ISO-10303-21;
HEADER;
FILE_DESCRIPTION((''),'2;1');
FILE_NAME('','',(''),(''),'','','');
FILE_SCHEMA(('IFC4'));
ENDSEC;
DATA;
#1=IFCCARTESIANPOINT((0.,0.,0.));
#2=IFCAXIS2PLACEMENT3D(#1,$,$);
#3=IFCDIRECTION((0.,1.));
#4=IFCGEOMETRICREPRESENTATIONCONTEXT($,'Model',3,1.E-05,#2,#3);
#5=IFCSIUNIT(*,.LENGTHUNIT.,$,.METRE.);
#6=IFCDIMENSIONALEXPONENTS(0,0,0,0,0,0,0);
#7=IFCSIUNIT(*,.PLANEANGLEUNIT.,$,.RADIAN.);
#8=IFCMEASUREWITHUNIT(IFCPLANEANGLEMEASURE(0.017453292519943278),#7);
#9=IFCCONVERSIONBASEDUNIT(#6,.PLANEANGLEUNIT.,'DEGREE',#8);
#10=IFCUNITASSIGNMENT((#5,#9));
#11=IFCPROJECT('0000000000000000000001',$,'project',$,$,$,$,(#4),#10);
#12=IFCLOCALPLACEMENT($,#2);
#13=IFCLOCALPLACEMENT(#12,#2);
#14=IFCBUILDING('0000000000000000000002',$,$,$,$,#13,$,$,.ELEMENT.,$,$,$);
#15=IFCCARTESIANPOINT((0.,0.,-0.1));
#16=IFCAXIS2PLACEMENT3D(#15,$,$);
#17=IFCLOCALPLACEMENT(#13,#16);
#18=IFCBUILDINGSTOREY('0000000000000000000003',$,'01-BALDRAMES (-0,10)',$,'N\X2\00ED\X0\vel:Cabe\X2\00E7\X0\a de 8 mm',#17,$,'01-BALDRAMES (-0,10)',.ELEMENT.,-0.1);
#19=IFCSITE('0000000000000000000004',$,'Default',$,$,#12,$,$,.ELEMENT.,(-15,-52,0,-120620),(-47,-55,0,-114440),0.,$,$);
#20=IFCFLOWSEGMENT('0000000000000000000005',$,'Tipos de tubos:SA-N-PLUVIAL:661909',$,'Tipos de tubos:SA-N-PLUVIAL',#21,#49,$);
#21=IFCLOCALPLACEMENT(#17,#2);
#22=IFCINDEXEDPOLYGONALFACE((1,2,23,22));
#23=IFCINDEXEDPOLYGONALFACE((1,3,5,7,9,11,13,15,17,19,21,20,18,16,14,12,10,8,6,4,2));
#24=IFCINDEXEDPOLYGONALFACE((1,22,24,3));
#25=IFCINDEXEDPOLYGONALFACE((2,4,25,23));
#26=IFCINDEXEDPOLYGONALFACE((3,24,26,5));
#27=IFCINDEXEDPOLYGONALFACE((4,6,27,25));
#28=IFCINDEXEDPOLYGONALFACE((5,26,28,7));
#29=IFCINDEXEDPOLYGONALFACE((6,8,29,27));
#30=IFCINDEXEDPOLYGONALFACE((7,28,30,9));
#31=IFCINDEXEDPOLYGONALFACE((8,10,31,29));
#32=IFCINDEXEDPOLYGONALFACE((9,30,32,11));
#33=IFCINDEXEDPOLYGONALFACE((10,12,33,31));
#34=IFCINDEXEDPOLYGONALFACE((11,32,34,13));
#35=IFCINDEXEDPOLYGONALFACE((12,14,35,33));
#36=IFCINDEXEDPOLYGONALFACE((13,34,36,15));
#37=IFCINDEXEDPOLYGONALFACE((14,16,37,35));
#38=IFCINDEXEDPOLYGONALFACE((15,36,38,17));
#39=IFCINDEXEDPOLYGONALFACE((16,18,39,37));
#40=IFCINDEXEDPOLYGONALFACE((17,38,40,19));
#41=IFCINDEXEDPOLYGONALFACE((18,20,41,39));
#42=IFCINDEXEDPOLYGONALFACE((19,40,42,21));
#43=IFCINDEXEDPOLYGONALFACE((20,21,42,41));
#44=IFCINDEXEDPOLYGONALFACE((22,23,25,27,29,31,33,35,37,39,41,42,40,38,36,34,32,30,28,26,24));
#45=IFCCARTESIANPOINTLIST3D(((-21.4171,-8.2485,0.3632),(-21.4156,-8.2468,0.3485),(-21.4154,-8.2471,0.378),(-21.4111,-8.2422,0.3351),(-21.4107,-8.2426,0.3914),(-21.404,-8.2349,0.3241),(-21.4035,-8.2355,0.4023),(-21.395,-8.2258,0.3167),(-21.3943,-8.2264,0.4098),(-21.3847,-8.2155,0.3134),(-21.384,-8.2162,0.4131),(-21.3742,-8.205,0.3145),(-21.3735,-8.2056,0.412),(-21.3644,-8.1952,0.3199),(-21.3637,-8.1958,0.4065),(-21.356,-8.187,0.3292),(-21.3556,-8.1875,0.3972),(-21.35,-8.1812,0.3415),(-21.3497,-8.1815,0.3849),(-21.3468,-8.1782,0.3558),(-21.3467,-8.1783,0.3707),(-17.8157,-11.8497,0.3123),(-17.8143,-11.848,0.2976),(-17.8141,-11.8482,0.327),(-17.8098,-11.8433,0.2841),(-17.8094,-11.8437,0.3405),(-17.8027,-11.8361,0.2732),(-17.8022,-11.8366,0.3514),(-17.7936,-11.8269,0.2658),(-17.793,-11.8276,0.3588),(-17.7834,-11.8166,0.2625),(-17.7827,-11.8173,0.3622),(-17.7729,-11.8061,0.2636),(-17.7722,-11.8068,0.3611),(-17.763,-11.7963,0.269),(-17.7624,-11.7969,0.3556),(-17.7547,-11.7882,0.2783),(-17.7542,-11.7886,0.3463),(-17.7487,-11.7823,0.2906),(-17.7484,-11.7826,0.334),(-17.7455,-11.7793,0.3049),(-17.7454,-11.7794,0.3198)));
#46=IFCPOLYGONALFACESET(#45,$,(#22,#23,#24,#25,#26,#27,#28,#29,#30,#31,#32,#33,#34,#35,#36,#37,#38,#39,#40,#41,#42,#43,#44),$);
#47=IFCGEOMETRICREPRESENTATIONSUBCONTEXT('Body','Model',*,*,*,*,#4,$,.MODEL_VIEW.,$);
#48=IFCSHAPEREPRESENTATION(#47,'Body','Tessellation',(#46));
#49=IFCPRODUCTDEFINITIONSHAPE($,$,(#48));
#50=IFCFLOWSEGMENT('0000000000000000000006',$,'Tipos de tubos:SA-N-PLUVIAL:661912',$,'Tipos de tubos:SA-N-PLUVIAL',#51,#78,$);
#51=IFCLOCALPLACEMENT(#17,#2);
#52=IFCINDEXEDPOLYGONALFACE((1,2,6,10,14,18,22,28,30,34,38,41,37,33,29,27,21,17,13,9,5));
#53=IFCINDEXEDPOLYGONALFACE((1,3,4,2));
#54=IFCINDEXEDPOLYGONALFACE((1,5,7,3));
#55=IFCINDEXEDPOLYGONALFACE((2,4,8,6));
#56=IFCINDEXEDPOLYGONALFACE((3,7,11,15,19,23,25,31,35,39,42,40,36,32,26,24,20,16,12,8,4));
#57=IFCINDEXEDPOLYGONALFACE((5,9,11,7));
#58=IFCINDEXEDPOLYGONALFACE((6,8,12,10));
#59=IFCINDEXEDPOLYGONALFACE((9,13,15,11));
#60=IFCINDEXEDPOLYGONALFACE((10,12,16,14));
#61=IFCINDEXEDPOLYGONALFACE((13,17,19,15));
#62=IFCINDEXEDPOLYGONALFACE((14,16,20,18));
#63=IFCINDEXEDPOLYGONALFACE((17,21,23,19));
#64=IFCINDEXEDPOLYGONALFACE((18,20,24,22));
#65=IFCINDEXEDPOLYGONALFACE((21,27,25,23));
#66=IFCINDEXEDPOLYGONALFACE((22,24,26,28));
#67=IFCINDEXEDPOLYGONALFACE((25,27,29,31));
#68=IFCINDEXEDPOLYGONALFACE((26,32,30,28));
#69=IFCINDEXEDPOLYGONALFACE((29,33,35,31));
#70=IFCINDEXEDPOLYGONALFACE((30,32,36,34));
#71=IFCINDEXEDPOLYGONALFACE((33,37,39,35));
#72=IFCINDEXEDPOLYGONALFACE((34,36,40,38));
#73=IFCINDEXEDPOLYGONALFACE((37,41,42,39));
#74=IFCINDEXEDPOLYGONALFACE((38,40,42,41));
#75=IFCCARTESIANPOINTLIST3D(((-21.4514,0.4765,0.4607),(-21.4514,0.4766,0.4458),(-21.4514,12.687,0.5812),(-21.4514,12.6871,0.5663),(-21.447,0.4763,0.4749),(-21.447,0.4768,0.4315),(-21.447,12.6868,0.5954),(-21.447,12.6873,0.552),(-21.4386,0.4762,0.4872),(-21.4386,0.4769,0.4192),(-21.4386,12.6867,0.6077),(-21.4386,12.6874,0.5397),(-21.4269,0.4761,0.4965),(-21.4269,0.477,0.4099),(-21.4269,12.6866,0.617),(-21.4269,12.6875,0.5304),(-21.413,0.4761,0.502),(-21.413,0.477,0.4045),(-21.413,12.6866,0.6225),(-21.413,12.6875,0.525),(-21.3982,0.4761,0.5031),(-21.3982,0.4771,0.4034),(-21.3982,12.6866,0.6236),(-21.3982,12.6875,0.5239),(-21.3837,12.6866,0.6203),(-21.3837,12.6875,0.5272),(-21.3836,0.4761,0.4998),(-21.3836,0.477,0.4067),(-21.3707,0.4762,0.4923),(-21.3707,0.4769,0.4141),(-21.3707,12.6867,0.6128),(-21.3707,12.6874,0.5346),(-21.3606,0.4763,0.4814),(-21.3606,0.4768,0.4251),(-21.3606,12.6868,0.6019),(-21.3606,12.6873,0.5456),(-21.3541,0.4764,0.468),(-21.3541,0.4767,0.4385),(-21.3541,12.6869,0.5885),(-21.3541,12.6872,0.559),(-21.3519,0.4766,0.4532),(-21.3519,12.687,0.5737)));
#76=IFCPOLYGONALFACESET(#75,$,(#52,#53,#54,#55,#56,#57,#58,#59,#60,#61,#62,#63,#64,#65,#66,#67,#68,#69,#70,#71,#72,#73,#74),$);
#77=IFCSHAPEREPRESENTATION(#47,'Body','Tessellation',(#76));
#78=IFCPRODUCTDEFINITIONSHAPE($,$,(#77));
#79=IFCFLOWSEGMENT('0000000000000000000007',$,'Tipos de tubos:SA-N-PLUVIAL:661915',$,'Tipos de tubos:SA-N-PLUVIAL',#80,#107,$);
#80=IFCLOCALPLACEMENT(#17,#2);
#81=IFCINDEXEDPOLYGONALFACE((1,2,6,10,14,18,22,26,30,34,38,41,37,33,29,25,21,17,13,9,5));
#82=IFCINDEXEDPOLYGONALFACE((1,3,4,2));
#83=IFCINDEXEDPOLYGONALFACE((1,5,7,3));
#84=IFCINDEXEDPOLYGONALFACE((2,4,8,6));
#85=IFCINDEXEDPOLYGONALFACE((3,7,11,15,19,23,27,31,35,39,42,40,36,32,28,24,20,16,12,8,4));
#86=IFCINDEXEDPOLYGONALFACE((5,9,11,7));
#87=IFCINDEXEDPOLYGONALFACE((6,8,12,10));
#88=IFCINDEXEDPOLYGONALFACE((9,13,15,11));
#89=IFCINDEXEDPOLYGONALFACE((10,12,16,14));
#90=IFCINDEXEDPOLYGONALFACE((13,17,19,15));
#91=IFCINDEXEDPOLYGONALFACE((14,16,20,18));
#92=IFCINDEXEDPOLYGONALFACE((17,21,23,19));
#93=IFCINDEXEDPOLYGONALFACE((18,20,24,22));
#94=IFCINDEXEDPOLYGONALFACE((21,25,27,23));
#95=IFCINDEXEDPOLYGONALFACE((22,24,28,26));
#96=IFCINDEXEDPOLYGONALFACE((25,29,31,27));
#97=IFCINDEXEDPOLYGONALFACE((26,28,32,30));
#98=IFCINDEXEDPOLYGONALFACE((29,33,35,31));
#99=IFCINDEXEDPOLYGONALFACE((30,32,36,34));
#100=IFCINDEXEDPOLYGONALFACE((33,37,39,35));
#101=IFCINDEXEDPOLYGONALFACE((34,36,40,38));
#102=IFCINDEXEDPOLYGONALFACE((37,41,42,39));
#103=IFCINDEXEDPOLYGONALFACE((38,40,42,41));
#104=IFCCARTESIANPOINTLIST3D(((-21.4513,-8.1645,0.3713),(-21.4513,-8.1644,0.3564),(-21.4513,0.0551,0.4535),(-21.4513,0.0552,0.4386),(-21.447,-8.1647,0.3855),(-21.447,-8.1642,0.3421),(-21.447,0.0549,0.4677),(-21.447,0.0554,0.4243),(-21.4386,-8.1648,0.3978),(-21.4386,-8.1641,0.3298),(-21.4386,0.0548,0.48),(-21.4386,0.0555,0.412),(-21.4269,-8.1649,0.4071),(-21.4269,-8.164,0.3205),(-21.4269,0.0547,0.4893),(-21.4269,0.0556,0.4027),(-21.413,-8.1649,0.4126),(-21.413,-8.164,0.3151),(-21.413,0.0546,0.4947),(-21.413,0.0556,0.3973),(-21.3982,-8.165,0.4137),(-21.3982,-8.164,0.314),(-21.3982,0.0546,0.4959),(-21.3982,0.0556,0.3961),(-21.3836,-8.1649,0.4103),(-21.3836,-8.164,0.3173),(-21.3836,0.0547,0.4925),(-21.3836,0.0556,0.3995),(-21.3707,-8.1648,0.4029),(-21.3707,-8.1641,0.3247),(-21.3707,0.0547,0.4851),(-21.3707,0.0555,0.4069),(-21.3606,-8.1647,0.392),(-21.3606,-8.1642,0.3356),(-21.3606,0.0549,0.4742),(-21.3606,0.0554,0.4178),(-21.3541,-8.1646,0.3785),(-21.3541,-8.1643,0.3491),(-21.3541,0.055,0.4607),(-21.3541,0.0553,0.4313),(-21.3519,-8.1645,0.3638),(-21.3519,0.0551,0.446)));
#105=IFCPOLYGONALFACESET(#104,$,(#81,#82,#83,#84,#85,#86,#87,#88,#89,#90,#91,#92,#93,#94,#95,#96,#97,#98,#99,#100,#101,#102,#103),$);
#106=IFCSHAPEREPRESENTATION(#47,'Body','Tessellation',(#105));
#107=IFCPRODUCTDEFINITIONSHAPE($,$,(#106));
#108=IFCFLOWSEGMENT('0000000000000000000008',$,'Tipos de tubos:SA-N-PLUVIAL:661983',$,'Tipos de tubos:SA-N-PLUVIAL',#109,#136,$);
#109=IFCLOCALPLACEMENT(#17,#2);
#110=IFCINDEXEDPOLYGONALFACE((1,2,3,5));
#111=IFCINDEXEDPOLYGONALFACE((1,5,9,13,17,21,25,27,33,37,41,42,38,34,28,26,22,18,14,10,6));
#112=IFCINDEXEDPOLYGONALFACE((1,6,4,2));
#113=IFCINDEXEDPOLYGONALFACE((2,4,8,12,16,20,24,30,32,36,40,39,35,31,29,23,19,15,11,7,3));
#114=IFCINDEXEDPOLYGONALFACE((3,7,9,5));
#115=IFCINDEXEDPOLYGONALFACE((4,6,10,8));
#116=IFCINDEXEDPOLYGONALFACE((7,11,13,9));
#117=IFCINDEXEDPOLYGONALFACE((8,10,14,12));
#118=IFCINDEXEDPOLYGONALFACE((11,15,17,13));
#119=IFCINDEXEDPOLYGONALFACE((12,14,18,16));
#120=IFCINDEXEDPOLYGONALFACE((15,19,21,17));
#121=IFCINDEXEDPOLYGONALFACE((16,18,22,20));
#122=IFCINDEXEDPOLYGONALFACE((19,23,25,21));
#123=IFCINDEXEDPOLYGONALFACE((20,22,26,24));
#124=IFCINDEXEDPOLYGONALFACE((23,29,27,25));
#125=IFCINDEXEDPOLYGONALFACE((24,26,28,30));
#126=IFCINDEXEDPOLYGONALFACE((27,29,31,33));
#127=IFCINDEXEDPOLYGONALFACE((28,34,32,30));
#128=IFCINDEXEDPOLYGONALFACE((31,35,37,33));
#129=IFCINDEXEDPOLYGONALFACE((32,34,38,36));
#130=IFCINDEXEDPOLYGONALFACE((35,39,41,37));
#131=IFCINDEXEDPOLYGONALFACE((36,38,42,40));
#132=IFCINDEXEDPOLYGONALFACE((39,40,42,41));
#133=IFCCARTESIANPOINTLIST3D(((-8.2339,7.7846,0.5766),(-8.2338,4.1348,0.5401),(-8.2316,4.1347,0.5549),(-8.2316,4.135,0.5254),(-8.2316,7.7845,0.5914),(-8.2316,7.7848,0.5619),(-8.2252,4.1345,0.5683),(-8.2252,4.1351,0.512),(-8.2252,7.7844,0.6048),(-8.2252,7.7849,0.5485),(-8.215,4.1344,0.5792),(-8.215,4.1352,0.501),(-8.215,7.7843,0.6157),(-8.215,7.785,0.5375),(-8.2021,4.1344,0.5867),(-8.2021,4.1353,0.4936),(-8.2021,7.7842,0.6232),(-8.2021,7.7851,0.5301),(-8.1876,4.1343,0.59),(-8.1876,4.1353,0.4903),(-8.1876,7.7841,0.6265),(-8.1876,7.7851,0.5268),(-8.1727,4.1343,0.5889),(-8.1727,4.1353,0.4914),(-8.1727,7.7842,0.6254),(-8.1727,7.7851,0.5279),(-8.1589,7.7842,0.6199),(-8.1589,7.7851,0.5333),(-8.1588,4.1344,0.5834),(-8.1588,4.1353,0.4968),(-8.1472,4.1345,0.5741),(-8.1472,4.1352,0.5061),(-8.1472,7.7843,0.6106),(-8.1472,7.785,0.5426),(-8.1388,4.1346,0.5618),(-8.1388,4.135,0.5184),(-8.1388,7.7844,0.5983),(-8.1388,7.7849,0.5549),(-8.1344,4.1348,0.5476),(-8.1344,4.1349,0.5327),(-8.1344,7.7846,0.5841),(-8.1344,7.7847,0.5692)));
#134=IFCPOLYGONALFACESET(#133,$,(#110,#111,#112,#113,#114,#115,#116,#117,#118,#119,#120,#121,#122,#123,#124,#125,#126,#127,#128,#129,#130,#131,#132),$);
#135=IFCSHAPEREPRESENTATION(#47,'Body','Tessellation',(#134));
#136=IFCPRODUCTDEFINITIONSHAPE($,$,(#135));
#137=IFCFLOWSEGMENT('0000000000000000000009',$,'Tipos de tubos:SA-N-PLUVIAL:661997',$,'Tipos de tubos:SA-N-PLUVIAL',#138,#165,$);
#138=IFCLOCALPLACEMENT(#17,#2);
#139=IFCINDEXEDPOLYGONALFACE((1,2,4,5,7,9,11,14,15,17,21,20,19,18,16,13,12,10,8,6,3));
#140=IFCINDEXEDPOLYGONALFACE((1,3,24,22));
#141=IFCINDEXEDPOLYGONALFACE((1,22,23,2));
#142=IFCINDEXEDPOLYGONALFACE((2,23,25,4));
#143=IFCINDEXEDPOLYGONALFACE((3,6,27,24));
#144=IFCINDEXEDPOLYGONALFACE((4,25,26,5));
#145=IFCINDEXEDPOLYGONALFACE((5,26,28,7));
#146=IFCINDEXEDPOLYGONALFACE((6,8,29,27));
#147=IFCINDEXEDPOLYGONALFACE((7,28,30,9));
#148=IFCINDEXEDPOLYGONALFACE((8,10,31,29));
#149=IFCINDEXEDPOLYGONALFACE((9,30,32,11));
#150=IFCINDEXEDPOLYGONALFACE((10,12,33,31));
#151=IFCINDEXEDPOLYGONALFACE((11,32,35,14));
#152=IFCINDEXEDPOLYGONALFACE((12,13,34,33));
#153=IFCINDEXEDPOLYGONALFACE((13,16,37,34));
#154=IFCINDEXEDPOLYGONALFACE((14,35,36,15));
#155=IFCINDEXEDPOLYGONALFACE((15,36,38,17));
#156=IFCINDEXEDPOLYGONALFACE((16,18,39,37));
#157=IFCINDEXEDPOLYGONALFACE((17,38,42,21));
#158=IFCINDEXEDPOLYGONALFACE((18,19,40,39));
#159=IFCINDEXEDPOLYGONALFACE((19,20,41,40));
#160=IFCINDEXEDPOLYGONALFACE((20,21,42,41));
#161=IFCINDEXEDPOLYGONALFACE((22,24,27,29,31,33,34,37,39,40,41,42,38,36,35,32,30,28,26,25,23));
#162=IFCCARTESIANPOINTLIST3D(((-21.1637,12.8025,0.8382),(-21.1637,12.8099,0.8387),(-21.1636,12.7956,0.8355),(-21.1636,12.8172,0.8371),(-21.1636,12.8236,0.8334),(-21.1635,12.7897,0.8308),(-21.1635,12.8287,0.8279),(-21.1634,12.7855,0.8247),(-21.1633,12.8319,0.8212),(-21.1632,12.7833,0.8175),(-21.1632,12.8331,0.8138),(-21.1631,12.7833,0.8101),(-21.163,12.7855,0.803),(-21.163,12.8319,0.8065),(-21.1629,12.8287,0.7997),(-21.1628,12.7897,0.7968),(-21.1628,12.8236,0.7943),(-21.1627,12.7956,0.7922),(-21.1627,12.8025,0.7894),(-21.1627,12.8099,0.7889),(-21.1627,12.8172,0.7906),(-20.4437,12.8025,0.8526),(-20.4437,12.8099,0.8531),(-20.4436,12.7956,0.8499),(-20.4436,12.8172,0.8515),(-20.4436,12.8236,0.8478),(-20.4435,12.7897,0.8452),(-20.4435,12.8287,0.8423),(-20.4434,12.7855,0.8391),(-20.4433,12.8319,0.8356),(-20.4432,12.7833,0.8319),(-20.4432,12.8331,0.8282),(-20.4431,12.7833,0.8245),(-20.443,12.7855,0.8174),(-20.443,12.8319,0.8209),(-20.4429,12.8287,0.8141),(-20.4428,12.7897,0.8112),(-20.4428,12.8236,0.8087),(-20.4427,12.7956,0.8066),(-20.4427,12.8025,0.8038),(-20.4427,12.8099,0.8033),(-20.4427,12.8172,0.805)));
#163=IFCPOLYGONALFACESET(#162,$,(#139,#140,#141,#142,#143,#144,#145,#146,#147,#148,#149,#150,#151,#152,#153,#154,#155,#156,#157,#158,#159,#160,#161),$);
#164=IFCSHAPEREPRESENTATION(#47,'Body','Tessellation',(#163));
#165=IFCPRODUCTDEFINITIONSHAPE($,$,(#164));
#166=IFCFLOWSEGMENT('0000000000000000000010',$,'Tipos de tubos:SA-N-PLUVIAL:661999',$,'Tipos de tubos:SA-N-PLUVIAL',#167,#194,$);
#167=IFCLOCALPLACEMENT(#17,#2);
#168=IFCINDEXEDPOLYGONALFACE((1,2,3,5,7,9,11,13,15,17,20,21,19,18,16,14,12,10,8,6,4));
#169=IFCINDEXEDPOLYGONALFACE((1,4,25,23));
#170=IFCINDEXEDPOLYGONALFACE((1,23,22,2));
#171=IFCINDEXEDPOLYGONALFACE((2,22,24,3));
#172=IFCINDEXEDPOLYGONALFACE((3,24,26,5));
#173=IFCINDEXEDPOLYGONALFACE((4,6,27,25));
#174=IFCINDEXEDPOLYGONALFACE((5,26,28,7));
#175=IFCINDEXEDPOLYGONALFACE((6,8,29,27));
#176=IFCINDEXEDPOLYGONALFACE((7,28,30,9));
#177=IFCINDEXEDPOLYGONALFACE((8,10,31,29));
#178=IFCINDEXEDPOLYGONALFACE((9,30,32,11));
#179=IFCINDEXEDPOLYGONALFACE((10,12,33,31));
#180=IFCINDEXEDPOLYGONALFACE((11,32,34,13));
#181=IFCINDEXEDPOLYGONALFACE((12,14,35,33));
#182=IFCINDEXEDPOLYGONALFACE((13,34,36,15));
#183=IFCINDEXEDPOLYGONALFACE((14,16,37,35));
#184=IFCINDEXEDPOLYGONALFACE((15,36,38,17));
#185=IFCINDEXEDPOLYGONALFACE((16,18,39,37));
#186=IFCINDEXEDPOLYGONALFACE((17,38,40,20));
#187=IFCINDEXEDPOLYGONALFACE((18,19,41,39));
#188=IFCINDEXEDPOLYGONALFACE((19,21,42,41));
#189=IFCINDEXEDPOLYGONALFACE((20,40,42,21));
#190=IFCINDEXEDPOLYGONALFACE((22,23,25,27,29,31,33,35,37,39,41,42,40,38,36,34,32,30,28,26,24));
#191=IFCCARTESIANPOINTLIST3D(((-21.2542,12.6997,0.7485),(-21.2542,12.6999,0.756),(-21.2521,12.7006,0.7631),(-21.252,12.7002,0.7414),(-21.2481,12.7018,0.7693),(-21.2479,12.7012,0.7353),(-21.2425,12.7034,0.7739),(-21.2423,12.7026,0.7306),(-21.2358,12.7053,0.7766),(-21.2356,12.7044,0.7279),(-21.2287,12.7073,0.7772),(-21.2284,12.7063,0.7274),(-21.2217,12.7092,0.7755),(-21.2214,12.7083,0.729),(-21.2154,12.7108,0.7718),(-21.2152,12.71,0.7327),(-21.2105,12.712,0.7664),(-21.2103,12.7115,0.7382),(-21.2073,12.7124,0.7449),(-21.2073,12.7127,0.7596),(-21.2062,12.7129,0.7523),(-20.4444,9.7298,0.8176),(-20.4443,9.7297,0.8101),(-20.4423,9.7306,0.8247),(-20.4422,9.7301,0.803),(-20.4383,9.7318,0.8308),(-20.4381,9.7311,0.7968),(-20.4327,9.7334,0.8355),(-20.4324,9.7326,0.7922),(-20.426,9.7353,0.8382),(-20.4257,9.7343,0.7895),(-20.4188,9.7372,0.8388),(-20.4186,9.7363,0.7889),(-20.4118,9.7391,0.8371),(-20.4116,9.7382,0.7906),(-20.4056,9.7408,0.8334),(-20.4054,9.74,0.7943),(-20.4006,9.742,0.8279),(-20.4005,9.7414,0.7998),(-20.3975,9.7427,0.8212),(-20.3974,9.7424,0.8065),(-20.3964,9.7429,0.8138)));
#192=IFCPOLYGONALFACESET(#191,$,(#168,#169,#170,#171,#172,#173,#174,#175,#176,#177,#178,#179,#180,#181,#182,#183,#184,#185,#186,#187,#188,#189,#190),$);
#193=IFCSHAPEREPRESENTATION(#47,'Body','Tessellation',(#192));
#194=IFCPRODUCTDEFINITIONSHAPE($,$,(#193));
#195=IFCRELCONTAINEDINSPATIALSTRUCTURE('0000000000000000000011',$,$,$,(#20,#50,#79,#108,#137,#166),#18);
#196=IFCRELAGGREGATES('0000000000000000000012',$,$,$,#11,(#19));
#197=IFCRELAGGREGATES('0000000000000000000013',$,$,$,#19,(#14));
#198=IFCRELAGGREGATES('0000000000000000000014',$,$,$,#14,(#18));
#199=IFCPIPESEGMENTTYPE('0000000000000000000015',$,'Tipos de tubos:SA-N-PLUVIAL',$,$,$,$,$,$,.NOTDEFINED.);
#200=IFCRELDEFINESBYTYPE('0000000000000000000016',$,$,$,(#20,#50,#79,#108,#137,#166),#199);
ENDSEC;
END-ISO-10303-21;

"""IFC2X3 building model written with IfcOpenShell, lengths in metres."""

from ifc_helpers import new_model, entity, si_unit, converted_unit, direction, frame, frame_2d, origin, origin_2d_with_axis, place, context, subcontext, project, spatial, circle, extrude, type_object, element, save


model = new_model("IFC2X3")

# Units and contexts
model_context = context("Model", 3, precision=1e-05, world=origin(), true_north=direction((0.0, 1.0)))
body_context = subcontext(model_context, "Body", "Model", "MODEL_VIEW")
ifc_project = project(units=[si_unit("LENGTHUNIT", "METRE"), converted_unit("PLANEANGLEUNIT", "DEGREE", entity("IfcPlaneAngleMeasure", 0.017453292519943278), si_unit("PLANEANGLEUNIT", "RADIAN"), dimensions=[0, 0, 0, 0, 0, 0, 0])], contexts=[model_context])

# Site, building, storey
site_placement = place(None, origin())
site = spatial("IfcSite", under=ifc_project, at=site_placement, Name="Default", CompositionType="ELEMENT", RefLatitude=(-15, -52, 0, -120620), RefLongitude=(-47, -55, 0, -114440), RefElevation=0.0)
building_placement = place(site_placement, origin())
building = spatial("IfcBuilding", under=site, at=building_placement, CompositionType="ELEMENT")
storey_placement = place(building_placement, frame((0.0, 0.0, -0.1)))
storey = spatial("IfcBuildingStorey", under=building, at=storey_placement, Name="01-BALDRAMES (-0,10)", ObjectType="Nível:Cabeça de 8 mm", LongName="01-BALDRAMES (-0,10)", CompositionType="ELEMENT", Elevation=-0.1)

# Flow segments
pipe_segment_type_1 = type_object("IfcPipeSegmentType", Name="Tipos de tubos:SA-N-PLUVIAL", PredefinedType="NOTDEFINED")
flow_segment_1_placement = place(storey_placement, origin())
element("IfcFlowSegment", 1, at=flow_segment_1_placement, inside=storey, type_object=pipe_segment_type_1, Name="Tipos de tubos:SA-N-PLUVIAL:661909", ObjectType="Tipos de tubos:SA-N-PLUVIAL", context=body_context, shape_type="SweptSolid", body=[
    extrude(circle(Radius=0.05, at=frame_2d((0.0, 0.0), x_axis=(1.0, 0.0))), frame((-17.7804, -11.8143, 0.3123), z_axis=(-0.70709, 0.707053, 0.01), x_axis=(-0.707089, -0.707125, 0.0)), (0.0, 0.0, 1.0), 5.0932),
])
flow_segment_2_placement = place(storey_placement, origin())
element("IfcFlowSegment", 2, at=flow_segment_2_placement, inside=storey, type_object=pipe_segment_type_1, Name="Tipos de tubos:SA-N-PLUVIAL:661912", ObjectType="Tipos de tubos:SA-N-PLUVIAL", context=body_context, shape_type="SweptSolid", body=[
    extrude(circle(Radius=0.05, at=frame_2d((0.0, 0.0), x_axis=(1.0, 0.0))), frame((-21.4019, 0.4766, 0.4532), z_axis=(-0.000001, 0.999951, 0.009868), x_axis=(1.0, 0.000001, 0.0)), (0.0, 0.0, 1.0), 12.2111),
])
flow_segment_3_placement = place(storey_placement, origin())
element("IfcFlowSegment", 3, at=flow_segment_3_placement, inside=storey, type_object=pipe_segment_type_1, Name="Tipos de tubos:SA-N-PLUVIAL:661915", ObjectType="Tipos de tubos:SA-N-PLUVIAL", context=body_context, shape_type="SweptSolid", body=[
    extrude(circle(Radius=0.05, at=frame_2d((0.0, 0.0), x_axis=(1.0, 0.0))), frame((-21.4019, -8.1645, 0.3638), z_axis=(-0.000001, 0.99995, 0.01), x_axis=(1.0, 0.000001, 0.0)), (0.0, 0.0, 1.0), 8.22),
])
flow_segment_4_placement = place(storey_placement, origin())
element("IfcFlowSegment", 4, at=flow_segment_4_placement, inside=storey, type_object=pipe_segment_type_1, Name="Tipos de tubos:SA-N-PLUVIAL:661983", ObjectType="Tipos de tubos:SA-N-PLUVIAL", context=body_context, shape_type="SweptSolid", body=[
    extrude(circle(Radius=0.05, at=frame_2d((0.0, 0.0), x_axis=(1.0, 0.0))), frame((-8.1838, 4.1348, 0.5401), z_axis=(-0.000001, 0.99995, 0.01), x_axis=(-1.0, -0.000001, 0.0)), (0.0, 0.0, 1.0), 3.65),
])
flow_segment_5_placement = place(storey_placement, origin())
element("IfcFlowSegment", 5, at=flow_segment_5_placement, inside=storey, type_object=pipe_segment_type_1, Name="Tipos de tubos:SA-N-PLUVIAL:661997", ObjectType="Tipos de tubos:SA-N-PLUVIAL", context=body_context, shape_type="SweptSolid", body=[
    extrude(circle(Radius=0.025, at=origin_2d_with_axis()), frame((-21.1632, 12.8081, 0.8138), z_axis=(0.9998, 0.000001, 0.019996), x_axis=(-0.000001, 1.0, 0.0)), (0.0, 0.0, 1.0), 0.7201),
])
flow_segment_6_placement = place(storey_placement, origin())
element("IfcFlowSegment", 6, at=flow_segment_6_placement, inside=storey, type_object=pipe_segment_type_1, Name="Tipos de tubos:SA-N-PLUVIAL:661999", ObjectType="Tipos de tubos:SA-N-PLUVIAL", context=body_context, shape_type="SweptSolid", body=[
    extrude(circle(Radius=0.025, at=origin_2d_with_axis()), frame((-20.4205, 9.7363, 0.8138), z_axis=(-0.263019, 0.964583, -0.019996), x_axis=(0.964776, 0.263071, 0.0)), (0.0, 0.0, 1.0), 3.0791),
])

save(model, "model.ifc")
